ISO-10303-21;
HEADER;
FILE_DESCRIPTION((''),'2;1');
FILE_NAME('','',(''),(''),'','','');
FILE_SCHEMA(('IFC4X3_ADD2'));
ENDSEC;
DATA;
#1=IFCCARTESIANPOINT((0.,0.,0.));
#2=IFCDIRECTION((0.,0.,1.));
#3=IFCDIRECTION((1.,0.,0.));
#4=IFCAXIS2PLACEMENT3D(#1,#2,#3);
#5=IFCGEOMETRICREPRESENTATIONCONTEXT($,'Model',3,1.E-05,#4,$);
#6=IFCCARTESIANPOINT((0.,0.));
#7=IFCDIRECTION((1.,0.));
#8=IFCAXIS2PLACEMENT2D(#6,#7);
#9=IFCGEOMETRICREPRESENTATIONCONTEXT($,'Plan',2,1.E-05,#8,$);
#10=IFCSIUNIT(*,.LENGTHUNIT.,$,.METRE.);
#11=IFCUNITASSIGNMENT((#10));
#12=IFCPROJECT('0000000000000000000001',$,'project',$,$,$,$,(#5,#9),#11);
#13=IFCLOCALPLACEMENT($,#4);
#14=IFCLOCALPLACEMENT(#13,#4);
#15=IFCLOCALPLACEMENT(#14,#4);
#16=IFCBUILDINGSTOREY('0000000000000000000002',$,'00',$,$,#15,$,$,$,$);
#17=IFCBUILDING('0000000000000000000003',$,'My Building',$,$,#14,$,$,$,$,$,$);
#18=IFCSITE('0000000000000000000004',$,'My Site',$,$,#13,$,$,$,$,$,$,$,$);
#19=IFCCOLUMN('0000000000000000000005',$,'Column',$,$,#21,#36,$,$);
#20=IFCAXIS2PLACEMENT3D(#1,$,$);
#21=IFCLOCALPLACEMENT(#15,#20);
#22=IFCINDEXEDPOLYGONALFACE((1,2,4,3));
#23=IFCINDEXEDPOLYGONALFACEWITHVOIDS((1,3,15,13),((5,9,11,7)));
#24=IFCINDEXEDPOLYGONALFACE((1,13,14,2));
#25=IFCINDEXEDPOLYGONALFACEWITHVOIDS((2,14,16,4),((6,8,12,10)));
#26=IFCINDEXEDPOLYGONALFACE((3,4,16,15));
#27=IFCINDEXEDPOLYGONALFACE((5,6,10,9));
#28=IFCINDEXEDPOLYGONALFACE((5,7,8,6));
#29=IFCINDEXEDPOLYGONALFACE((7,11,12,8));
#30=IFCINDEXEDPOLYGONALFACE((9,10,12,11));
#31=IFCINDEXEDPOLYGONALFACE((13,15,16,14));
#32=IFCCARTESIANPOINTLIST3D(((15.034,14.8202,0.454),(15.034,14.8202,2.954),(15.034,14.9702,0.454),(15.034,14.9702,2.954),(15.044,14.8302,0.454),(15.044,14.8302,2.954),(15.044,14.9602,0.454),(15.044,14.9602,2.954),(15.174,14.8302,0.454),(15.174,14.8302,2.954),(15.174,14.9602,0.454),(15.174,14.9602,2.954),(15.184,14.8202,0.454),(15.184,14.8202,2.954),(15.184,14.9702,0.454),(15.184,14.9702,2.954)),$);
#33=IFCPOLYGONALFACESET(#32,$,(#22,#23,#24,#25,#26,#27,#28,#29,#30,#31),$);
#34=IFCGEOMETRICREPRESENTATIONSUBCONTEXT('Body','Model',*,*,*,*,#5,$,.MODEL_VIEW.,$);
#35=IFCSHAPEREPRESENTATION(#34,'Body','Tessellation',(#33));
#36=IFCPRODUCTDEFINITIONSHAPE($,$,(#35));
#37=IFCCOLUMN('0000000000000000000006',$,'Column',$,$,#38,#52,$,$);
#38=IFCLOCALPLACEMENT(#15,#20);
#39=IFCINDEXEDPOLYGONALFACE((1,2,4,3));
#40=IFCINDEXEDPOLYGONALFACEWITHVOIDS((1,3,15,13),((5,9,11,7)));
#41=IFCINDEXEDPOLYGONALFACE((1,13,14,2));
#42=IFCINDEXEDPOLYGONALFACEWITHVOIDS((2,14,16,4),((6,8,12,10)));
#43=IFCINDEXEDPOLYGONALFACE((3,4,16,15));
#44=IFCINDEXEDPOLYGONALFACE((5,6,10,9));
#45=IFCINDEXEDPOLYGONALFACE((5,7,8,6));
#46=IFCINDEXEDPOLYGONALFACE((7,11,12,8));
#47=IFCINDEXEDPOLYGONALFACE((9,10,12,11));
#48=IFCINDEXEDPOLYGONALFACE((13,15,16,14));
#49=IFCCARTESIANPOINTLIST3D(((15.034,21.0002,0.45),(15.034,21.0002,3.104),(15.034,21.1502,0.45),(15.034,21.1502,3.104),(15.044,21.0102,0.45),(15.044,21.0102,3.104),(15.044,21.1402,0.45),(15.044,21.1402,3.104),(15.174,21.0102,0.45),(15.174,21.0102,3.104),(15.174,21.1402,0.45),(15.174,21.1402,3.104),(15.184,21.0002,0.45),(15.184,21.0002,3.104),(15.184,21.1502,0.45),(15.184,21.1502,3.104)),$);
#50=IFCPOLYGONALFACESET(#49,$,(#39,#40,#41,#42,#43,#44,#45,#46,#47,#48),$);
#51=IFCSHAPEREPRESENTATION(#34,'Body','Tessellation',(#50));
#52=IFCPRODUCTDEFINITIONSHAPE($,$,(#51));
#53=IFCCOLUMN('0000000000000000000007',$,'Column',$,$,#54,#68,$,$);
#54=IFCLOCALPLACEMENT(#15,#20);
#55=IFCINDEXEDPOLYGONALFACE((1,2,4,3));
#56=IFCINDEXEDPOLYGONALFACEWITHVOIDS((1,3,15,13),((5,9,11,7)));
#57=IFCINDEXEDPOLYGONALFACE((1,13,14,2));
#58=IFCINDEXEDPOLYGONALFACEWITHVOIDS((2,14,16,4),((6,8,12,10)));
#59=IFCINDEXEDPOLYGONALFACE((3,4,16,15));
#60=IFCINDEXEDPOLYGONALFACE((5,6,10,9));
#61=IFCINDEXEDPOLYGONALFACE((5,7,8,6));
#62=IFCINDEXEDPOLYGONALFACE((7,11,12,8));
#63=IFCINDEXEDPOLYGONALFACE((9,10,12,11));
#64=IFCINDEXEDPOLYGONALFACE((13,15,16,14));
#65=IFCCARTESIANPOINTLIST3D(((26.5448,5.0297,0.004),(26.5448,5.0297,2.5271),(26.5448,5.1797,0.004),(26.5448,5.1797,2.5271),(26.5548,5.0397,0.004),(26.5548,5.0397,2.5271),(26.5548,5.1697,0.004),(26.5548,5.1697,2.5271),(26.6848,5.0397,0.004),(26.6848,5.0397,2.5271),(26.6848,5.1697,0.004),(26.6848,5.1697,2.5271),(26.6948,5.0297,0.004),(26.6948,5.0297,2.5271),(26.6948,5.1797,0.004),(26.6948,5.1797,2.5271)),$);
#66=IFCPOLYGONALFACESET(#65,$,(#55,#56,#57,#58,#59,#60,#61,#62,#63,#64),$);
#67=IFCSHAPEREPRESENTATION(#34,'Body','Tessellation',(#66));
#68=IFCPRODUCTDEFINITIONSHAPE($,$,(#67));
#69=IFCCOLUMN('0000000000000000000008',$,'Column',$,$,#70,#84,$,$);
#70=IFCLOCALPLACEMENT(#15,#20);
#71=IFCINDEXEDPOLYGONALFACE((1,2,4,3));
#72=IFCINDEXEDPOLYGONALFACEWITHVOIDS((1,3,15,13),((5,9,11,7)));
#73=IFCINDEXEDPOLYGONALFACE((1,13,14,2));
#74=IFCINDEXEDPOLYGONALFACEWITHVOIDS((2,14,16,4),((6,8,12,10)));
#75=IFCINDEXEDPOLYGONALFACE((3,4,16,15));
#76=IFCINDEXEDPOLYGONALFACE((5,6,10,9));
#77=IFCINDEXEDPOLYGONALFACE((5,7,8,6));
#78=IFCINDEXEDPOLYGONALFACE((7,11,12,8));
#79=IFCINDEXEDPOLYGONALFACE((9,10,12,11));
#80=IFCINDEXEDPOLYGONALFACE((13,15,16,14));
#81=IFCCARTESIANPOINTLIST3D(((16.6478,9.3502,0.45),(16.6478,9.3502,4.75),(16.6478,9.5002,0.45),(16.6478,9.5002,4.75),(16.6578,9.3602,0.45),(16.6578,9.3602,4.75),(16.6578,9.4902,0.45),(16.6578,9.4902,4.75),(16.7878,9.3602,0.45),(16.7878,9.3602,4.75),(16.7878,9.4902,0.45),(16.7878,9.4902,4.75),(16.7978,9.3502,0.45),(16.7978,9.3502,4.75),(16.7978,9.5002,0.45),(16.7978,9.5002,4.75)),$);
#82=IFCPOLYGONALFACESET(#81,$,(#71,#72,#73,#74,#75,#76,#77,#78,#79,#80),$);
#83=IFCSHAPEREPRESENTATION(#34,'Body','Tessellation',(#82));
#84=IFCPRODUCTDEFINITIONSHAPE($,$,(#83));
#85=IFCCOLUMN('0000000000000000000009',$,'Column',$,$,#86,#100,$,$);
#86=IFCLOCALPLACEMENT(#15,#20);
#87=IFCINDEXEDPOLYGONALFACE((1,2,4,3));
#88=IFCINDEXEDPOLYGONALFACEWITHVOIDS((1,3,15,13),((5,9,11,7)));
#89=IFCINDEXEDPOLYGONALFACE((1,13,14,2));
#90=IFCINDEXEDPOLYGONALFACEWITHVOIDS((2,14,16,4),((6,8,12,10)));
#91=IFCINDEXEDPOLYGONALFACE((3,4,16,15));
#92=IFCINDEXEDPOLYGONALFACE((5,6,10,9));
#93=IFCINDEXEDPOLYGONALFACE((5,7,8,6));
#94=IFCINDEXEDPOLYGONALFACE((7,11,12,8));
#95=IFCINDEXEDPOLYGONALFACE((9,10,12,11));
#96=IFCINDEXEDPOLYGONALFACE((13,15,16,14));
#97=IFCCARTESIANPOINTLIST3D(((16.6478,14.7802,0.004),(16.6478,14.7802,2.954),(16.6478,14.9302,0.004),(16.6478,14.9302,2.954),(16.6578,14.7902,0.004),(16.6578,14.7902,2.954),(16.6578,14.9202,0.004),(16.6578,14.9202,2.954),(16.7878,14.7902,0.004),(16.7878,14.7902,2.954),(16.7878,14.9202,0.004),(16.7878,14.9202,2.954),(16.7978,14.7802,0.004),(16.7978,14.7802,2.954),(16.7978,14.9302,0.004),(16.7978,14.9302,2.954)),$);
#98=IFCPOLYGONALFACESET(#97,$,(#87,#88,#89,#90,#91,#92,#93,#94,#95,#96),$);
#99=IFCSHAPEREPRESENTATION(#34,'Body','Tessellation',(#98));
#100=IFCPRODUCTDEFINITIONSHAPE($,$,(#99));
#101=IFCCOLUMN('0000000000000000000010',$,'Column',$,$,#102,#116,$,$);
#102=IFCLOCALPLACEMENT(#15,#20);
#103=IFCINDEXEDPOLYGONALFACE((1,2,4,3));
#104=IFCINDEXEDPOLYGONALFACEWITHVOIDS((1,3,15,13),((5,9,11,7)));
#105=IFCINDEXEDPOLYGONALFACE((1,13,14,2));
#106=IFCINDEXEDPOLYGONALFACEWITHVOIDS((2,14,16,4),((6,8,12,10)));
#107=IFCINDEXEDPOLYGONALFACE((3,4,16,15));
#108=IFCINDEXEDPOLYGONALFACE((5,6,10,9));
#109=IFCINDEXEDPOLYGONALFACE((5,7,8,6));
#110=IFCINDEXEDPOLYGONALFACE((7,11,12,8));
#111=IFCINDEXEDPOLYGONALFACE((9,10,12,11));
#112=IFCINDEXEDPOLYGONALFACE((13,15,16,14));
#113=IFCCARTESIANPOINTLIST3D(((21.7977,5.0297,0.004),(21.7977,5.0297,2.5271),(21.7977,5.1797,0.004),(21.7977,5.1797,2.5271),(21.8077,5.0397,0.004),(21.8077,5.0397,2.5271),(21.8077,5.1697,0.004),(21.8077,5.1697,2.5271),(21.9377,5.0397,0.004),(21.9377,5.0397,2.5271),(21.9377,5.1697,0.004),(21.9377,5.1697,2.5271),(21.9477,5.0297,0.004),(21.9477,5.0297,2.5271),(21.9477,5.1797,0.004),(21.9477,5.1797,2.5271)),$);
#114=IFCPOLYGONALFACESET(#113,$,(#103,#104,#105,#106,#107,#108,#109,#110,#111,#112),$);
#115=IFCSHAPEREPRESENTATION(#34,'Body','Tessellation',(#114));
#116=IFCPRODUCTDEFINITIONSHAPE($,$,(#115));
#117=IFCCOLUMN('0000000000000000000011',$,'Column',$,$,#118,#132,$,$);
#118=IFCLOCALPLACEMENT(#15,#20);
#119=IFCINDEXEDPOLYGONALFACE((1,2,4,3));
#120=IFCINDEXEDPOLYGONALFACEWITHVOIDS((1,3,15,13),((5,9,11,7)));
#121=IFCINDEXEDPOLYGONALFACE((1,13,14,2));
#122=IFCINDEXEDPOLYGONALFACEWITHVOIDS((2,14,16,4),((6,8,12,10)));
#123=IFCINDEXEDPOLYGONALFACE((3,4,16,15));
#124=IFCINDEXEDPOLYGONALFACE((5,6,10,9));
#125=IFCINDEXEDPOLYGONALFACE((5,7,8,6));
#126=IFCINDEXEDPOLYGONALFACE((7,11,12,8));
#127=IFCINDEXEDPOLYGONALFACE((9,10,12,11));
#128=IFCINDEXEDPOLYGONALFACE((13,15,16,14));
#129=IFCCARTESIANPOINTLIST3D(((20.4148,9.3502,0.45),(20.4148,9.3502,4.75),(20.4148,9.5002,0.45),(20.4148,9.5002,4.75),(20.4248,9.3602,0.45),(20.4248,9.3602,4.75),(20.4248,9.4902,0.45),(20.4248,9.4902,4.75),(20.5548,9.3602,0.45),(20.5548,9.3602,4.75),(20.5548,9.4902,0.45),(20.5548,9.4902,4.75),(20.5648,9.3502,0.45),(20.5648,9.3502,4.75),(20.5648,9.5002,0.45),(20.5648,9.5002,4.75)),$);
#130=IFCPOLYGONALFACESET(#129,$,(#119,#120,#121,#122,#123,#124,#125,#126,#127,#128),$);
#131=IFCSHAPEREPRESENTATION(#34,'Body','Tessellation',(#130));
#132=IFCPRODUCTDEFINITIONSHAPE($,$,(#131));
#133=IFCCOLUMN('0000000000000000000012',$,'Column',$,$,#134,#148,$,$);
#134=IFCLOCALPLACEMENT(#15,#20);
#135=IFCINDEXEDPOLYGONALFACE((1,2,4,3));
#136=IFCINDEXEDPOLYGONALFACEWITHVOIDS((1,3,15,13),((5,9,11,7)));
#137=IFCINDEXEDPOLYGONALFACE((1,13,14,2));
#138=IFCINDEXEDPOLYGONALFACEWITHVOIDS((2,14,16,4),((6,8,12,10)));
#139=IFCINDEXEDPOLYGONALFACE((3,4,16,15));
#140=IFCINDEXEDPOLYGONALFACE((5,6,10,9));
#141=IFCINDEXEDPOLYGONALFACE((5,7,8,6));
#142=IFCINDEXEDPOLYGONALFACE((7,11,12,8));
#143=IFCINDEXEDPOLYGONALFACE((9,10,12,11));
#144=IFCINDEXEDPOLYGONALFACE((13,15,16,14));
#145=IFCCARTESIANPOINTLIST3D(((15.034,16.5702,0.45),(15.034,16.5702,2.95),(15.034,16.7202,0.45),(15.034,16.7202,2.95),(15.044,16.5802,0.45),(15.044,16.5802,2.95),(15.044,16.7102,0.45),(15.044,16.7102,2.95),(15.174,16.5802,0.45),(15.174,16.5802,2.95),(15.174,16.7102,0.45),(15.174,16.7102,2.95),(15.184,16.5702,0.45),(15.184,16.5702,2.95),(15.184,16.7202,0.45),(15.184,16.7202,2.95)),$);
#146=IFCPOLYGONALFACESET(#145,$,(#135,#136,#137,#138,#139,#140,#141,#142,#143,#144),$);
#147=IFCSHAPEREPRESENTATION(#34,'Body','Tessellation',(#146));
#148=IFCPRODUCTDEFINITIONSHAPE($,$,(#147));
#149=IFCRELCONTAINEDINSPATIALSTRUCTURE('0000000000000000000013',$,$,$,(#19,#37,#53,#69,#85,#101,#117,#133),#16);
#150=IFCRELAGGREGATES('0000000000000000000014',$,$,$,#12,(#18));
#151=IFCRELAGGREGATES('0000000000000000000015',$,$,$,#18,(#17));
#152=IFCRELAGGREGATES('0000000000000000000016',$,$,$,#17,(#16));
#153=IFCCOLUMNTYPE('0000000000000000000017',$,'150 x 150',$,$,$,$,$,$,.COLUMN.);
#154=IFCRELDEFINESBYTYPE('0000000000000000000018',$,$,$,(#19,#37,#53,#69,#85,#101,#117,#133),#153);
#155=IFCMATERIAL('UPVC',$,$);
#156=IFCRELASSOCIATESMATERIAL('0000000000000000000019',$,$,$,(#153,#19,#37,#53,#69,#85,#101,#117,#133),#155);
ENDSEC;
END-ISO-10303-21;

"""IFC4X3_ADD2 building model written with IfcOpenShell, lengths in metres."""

from ifc_helpers import new_model, entity, si_unit, frame, origin_with_axes, origin_2d_with_axis, place, context, subcontext, project, spatial, hollow_rectangle, extrude, shape, material, material_profile, profile_set, profile_usage, type_object, element, save


model = new_model("IFC4X3_ADD2")

# Units and contexts
model_context = context("Model", 3, precision=1e-05, world=origin_with_axes())
plan_context = context("Plan", 2, precision=1e-05, world=origin_2d_with_axis())
body_context_1 = subcontext(model_context, "Body", "Model", "MODEL_VIEW")
body_context_2 = subcontext(plan_context, "Body", "Plan", "PLAN_VIEW")
ifc_project = project(units=[si_unit("LENGTHUNIT", "METRE")], contexts=[model_context, plan_context])

# Site, building, storey
site_placement = place(None, origin_with_axes())
site = spatial("IfcSite", under=ifc_project, at=site_placement, Name="My Site")
building_placement = place(site_placement, origin_with_axes())
building = spatial("IfcBuilding", under=site, at=building_placement, Name="My Building")
storey_placement = place(building_placement, origin_with_axes())
storey = spatial("IfcBuildingStorey", under=building, at=storey_placement, Name="00")

# Columns
ifc_material_1 = material(Name="UPVC")
ifc_material_profile = material_profile(ifc_material_1, hollow_rectangle(XDim=0.15, YDim=0.15, WallThickness=0.01))
ifc_profile_set = profile_set([ifc_material_profile])
ifc_profile_usage_1 = profile_usage(ifc_profile_set)
column_type = type_object("IfcColumnType", Name="150 x 150", PredefinedType="COLUMN", material=ifc_profile_set)
column_1_placement = place(storey_placement, frame((15.109, 14.8952, 0.454), z_axis=(0.0, 0.0, 1.0), x_axis=(1.0, 0.0, 0.0)))
element("IfcColumn", 1, at=column_1_placement, inside=storey, type_object=column_type, material=ifc_profile_usage_1, Name="Column", shapes=[
    shape(body_context_1, "Body", "SweptSolid", [extrude(hollow_rectangle(XDim=0.15, YDim=0.15, WallThickness=0.01), origin_with_axes(), (0.0, 0.0, 1.0), 2.5)]),
    shape(body_context_2, "Body", "Annotation2D", [entity("IfcGeometricCurveSet", [entity("IfcIndexedPolyCurve", entity("IfcCartesianPointList2D", [[0.065, 0.065], [0.065, -0.065], [-0.065, -0.065], [-0.065, 0.065]]), [entity("IfcLineIndex", [1, 2, 3, 4, 1])]), entity("IfcIndexedPolyCurve", entity("IfcCartesianPointList2D", [[-0.075, -0.075], [0.075, -0.075], [0.075, 0.075], [-0.075, 0.075]]), [entity("IfcLineIndex", [1, 2, 3, 4, 1])])])]),
])
ifc_profile_usage_2 = profile_usage(ifc_profile_set)
column_2_placement = place(storey_placement, frame((15.109, 21.0752, 0.45), z_axis=(0.0, 0.0, 1.0), x_axis=(1.0, 0.0, 0.0)))
element("IfcColumn", 2, at=column_2_placement, inside=storey, type_object=column_type, material=ifc_profile_usage_2, Name="Column", shapes=[
    shape(body_context_1, "Body", "SweptSolid", [extrude(hollow_rectangle(XDim=0.15, YDim=0.15, WallThickness=0.01), origin_with_axes(), (0.0, 0.0, 1.0), 2.654)]),
    shape(body_context_2, "Body", "Annotation2D", [entity("IfcGeometricCurveSet", [entity("IfcIndexedPolyCurve", entity("IfcCartesianPointList2D", [[0.065, -0.065], [0.065, 0.065], [-0.065, 0.065], [-0.065, -0.065]]), [entity("IfcLineIndex", [1, 2, 3, 4, 1])]), entity("IfcIndexedPolyCurve", entity("IfcCartesianPointList2D", [[0.075, -0.075], [-0.075, -0.075], [-0.075, 0.075], [0.075, 0.075]]), [entity("IfcLineIndex", [1, 2, 3, 4, 1])])])]),
])
ifc_profile_usage_3 = profile_usage(ifc_profile_set, cardinal=5)
column_3_placement = place(storey_placement, frame((26.6198, 5.1047, 0.004), z_axis=(0.0, 0.0, 1.0), x_axis=(1.0, 0.0, 0.0)))
element("IfcColumn", 3, at=column_3_placement, inside=storey, type_object=column_type, material=ifc_profile_usage_3, Name="Column", shapes=[
    shape(body_context_1, "Body", "SweptSolid", [extrude(hollow_rectangle(XDim=0.15, YDim=0.15, WallThickness=0.01), origin_with_axes(), (0.0, 0.0, 1.0), 2.5231)]),
    shape(body_context_2, "Body", "Annotation2D", [entity("IfcGeometricCurveSet", [entity("IfcIndexedPolyCurve", entity("IfcCartesianPointList2D", [[-0.075, -0.075], [-0.075, 0.075], [0.075, 0.075], [0.075, -0.075]]), [entity("IfcLineIndex", [1, 2, 3, 4, 1])]), entity("IfcIndexedPolyCurve", entity("IfcCartesianPointList2D", [[0.065, 0.065], [-0.065, 0.065], [-0.065, -0.065], [0.065, -0.065]]), [entity("IfcLineIndex", [1, 2, 3, 4, 1])])])]),
])
ifc_profile_usage_4 = profile_usage(ifc_profile_set, cardinal=5)
column_4_placement = place(storey_placement, frame((16.7228, 9.4252, 0.45), z_axis=(0.0, 0.0, 1.0), x_axis=(1.0, 0.0, 0.0)))
element("IfcColumn", 4, at=column_4_placement, inside=storey, type_object=column_type, material=ifc_profile_usage_4, Name="Column", shapes=[
    shape(body_context_1, "Body", "SweptSolid", [extrude(hollow_rectangle(XDim=0.15, YDim=0.15, WallThickness=0.01), origin_with_axes(), (0.0, 0.0, 1.0), 4.3)]),
    shape(body_context_2, "Body", "Annotation2D", [entity("IfcGeometricCurveSet", [entity("IfcIndexedPolyCurve", entity("IfcCartesianPointList2D", [[0.065, -0.065], [-0.065, -0.065], [-0.065, 0.065], [0.065, 0.065]]), [entity("IfcLineIndex", [1, 2, 3, 4, 1])]), entity("IfcIndexedPolyCurve", entity("IfcCartesianPointList2D", [[-0.075, 0.075], [0.075, 0.075], [0.075, -0.075], [-0.075, -0.075]]), [entity("IfcLineIndex", [1, 2, 3, 4, 1])])])]),
])
ifc_profile_usage_5 = profile_usage(ifc_profile_set, cardinal=5)
column_5_placement = place(storey_placement, frame((16.7228, 14.8552, 0.004), z_axis=(0.0, 0.0, 1.0), x_axis=(1.0, 0.0, 0.0)))
element("IfcColumn", 5, at=column_5_placement, inside=storey, type_object=column_type, material=ifc_profile_usage_5, Name="Column", shapes=[
    shape(body_context_1, "Body", "SweptSolid", [extrude(hollow_rectangle(XDim=0.15, YDim=0.15, WallThickness=0.01), origin_with_axes(), (0.0, 0.0, 1.0), 2.95)]),
    shape(body_context_2, "Body", "Annotation2D", [entity("IfcGeometricCurveSet", [entity("IfcIndexedPolyCurve", entity("IfcCartesianPointList2D", [[-0.075, -0.075], [-0.075, 0.075], [0.075, 0.075], [0.075, -0.075]]), [entity("IfcLineIndex", [1, 2, 3, 4, 1])]), entity("IfcIndexedPolyCurve", entity("IfcCartesianPointList2D", [[-0.065, -0.065], [0.065, -0.065], [0.065, 0.065], [-0.065, 0.065]]), [entity("IfcLineIndex", [1, 2, 3, 4, 1])])])]),
])
ifc_profile_usage_6 = profile_usage(ifc_profile_set, cardinal=5)
column_6_placement = place(storey_placement, frame((21.8727, 5.1047, 0.004), z_axis=(0.0, 0.0, 1.0), x_axis=(1.0, 0.0, 0.0)))
element("IfcColumn", 6, at=column_6_placement, inside=storey, type_object=column_type, material=ifc_profile_usage_6, Name="Column", shapes=[
    shape(body_context_1, "Body", "SweptSolid", [extrude(hollow_rectangle(XDim=0.15, YDim=0.15, WallThickness=0.01), origin_with_axes(), (0.0, 0.0, 1.0), 2.5231)]),
    shape(body_context_2, "Body", "Annotation2D", [entity("IfcGeometricCurveSet", [entity("IfcIndexedPolyCurve", entity("IfcCartesianPointList2D", [[0.075, 0.075], [0.075, -0.075], [-0.075, -0.075], [-0.075, 0.075]]), [entity("IfcLineIndex", [1, 2, 3, 4, 1])]), entity("IfcIndexedPolyCurve", entity("IfcCartesianPointList2D", [[-0.065, 0.065], [0.065, 0.065], [0.065, -0.065], [-0.065, -0.065]]), [entity("IfcLineIndex", [1, 2, 3, 4, 1])])])]),
])
ifc_profile_usage_7 = profile_usage(ifc_profile_set, cardinal=5)
column_7_placement = place(storey_placement, frame((20.4898, 9.4252, 0.45), z_axis=(0.0, 0.0, 1.0), x_axis=(1.0, 0.0, 0.0)))
element("IfcColumn", 7, at=column_7_placement, inside=storey, type_object=column_type, material=ifc_profile_usage_7, Name="Column", shapes=[
    shape(body_context_1, "Body", "SweptSolid", [extrude(hollow_rectangle(XDim=0.15, YDim=0.15, WallThickness=0.01), origin_with_axes(), (0.0, 0.0, 1.0), 4.3)]),
    shape(body_context_2, "Body", "Annotation2D", [entity("IfcGeometricCurveSet", [entity("IfcIndexedPolyCurve", entity("IfcCartesianPointList2D", [[-0.075, -0.075], [-0.075, 0.075], [0.075, 0.075], [0.075, -0.075]]), [entity("IfcLineIndex", [1, 2, 3, 4, 1])]), entity("IfcIndexedPolyCurve", entity("IfcCartesianPointList2D", [[-0.065, -0.065], [0.065, -0.065], [0.065, 0.065], [-0.065, 0.065]]), [entity("IfcLineIndex", [1, 2, 3, 4, 1])])])]),
])
ifc_profile_usage_8 = profile_usage(ifc_profile_set)
column_8_placement = place(storey_placement, frame((15.109, 16.6452, 0.45), z_axis=(0.0, 0.0, 1.0), x_axis=(1.0, 0.0, 0.0)))
element("IfcColumn", 8, at=column_8_placement, inside=storey, type_object=column_type, material=ifc_profile_usage_8, Name="Column", shapes=[
    shape(body_context_1, "Body", "SweptSolid", [extrude(hollow_rectangle(XDim=0.15, YDim=0.15, WallThickness=0.01), origin_with_axes(), (0.0, 0.0, 1.0), 2.5)]),
    shape(body_context_2, "Body", "Annotation2D", [entity("IfcGeometricCurveSet", [entity("IfcIndexedPolyCurve", entity("IfcCartesianPointList2D", [[-0.075, -0.075], [0.075, -0.075], [0.075, 0.075], [-0.075, 0.075]]), [entity("IfcLineIndex", [1, 2, 3, 4, 1])]), entity("IfcIndexedPolyCurve", entity("IfcCartesianPointList2D", [[0.065, -0.065], [-0.065, -0.065], [-0.065, 0.065], [0.065, 0.065]]), [entity("IfcLineIndex", [1, 2, 3, 4, 1])])])]),
])

save(model, "model.ifc")
